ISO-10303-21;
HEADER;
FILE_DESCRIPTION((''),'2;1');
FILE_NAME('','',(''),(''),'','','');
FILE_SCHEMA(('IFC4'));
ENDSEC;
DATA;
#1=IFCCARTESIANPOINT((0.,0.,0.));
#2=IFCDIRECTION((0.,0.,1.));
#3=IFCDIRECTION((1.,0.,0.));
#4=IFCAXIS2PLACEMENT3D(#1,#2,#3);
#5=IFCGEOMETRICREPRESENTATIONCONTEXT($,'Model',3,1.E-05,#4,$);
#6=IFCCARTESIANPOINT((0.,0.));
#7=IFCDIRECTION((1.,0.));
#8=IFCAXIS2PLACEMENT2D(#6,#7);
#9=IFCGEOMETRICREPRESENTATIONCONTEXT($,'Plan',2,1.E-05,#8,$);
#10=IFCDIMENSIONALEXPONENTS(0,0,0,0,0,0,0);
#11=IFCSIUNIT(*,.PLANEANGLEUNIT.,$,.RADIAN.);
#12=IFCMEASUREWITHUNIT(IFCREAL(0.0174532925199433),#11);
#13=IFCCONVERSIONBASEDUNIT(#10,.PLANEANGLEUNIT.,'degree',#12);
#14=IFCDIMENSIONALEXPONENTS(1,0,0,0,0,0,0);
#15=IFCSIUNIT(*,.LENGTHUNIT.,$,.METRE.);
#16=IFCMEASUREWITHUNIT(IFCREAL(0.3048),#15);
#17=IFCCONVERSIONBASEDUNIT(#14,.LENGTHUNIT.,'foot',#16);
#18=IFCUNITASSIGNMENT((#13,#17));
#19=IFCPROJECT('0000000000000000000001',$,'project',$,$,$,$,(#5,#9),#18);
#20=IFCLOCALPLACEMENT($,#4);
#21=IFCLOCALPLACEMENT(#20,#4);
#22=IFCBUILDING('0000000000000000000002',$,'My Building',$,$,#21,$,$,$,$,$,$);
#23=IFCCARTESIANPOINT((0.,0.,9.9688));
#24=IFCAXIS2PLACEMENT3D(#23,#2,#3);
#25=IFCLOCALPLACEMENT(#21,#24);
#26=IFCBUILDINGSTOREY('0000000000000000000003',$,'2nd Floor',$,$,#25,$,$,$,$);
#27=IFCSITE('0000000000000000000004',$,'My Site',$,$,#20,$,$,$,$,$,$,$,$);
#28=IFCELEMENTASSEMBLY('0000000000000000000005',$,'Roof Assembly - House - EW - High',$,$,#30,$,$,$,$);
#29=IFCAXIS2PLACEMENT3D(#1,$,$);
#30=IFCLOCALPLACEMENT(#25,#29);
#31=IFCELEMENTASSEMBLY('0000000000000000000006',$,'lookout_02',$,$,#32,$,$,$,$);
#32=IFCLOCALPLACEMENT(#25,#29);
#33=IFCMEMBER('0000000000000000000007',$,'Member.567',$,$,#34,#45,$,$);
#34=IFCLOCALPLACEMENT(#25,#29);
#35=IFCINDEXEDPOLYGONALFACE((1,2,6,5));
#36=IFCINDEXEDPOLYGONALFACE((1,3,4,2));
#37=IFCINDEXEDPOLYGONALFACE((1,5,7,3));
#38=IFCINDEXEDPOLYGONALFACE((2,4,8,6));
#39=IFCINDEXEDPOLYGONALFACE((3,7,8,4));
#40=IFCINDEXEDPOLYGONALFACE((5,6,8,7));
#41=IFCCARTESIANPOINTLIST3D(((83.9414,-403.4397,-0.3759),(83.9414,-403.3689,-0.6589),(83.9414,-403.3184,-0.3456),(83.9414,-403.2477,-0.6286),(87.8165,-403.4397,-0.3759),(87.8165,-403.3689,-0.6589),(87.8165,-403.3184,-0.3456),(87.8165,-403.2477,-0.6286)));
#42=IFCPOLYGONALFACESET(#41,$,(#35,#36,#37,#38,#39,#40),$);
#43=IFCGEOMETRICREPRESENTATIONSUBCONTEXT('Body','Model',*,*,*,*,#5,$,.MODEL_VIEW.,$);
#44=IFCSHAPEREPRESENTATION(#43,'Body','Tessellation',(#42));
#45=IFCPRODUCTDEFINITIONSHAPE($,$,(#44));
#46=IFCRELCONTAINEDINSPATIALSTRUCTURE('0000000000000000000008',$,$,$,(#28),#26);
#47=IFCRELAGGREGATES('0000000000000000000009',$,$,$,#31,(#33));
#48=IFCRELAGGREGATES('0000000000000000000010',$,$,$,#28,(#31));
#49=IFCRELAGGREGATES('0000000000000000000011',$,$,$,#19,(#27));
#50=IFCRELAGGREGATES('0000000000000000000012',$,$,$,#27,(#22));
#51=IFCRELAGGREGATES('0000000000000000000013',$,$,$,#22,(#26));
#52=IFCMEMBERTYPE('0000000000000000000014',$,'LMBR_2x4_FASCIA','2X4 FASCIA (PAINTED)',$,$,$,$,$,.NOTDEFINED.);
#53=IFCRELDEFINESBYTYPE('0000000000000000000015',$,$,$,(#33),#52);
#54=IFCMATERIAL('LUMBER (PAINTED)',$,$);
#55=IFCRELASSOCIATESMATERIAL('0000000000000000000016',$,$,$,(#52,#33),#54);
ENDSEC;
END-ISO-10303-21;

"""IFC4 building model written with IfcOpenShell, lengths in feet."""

from ifc_helpers import new_model, entity, si_unit, converted_unit, frame, origin_with_axes, origin_2d_with_axis, place, context, subcontext, project, spatial, indexed_curve, outline, extrude, material, material_profile, profile_set, profile_usage, type_object, element, aggregate, save


model = new_model("IFC4")

# Units and contexts
model_context = context("Model", 3, precision=1e-05, world=origin_with_axes())
plan_context = context("Plan", 2, precision=1e-05, world=origin_2d_with_axis())
body_context = subcontext(model_context, "Body", "Model", "MODEL_VIEW")
ifc_project = project(units=[converted_unit("PLANEANGLEUNIT", "degree", entity("IfcReal", 0.0174532925199433), si_unit("PLANEANGLEUNIT", "RADIAN"), dimensions=[0, 0, 0, 0, 0, 0, 0]), converted_unit("LENGTHUNIT", "foot", entity("IfcReal", 0.3048), si_unit("LENGTHUNIT", "METRE"), dimensions=[1, 0, 0, 0, 0, 0, 0])], contexts=[model_context, plan_context])

# Site, building, storey
site_placement = place(None, origin_with_axes())
site = spatial("IfcSite", under=ifc_project, at=site_placement, Name="My Site")
building_placement = place(site_placement, origin_with_axes())
building = spatial("IfcBuilding", under=site, at=building_placement, Name="My Building")
storey_placement = place(building_placement, frame((0.0, 0.0, 9.9688), z_axis=(0.0, 0.0, 1.0), x_axis=(1.0, 0.0, 0.0)))
storey = spatial("IfcBuildingStorey", under=building, at=storey_placement, Name="2nd Floor")

# Element assemblies, member
assembly_1_placement = place(storey_placement, frame((0.0, 0.0, -9.9063), z_axis=(0.0, 0.0, 1.0), x_axis=(1.0, 0.0, 0.0)))
assembly_1 = element("IfcElementAssembly", 1, at=assembly_1_placement, inside=storey, Name="Roof Assembly - House - EW - High")
ifc_material_1 = material(Name="LUMBER (PAINTED)")
assembly_2_placement = place(assembly_1_placement, frame((83.9414, -391.7532, 12.5192), z_axis=(0.0, 0.0, 1.0), x_axis=(0.000001, -1.0, 0.0)))
assembly_2 = element("IfcElementAssembly", 2, at=assembly_2_placement, Name="lookout_02")
ifc_material_profile_1 = material_profile(ifc_material_1, outline(indexed_curve([(-0.0625, -0.1458), (0.0625, -0.1458), (0.0625, 0.1458), (-0.0625, 0.1458), (-0.0625, -0.1458)])))
ifc_profile_set_1 = profile_set([ifc_material_profile_1])
ifc_profile_usage_1 = profile_usage(ifc_profile_set_1)
member_type_1 = type_object("IfcMemberType", Name="LMBR_2x4_FASCIA", Description="2X4 FASCIA (PAINTED)", PredefinedType="NOTDEFINED", material=ifc_profile_set_1)
member_1_placement = place(assembly_2_placement, frame((11.5905, 0.0, -3.1152), z_axis=(0.0, 1.0, 0.0), x_axis=(-0.970127, 0.0, 0.242599)))
member_1 = element("IfcMember", 3, at=member_1_placement, type_object=member_type_1, material=ifc_profile_usage_1, Name="Member.567", context=body_context, shape_type="SweptSolid", body=[
    extrude(outline(indexed_curve([(-0.0625, -0.1458), (0.0625, -0.1458), (0.0625, 0.1458), (-0.0625, 0.1458), (-0.0625, -0.1458)])), origin_with_axes(), (0.0, 0.0, 1.0), 3.875),
])
aggregate(assembly_2, [member_1])
aggregate(assembly_1, [assembly_2])

save(model, "model.ifc")
